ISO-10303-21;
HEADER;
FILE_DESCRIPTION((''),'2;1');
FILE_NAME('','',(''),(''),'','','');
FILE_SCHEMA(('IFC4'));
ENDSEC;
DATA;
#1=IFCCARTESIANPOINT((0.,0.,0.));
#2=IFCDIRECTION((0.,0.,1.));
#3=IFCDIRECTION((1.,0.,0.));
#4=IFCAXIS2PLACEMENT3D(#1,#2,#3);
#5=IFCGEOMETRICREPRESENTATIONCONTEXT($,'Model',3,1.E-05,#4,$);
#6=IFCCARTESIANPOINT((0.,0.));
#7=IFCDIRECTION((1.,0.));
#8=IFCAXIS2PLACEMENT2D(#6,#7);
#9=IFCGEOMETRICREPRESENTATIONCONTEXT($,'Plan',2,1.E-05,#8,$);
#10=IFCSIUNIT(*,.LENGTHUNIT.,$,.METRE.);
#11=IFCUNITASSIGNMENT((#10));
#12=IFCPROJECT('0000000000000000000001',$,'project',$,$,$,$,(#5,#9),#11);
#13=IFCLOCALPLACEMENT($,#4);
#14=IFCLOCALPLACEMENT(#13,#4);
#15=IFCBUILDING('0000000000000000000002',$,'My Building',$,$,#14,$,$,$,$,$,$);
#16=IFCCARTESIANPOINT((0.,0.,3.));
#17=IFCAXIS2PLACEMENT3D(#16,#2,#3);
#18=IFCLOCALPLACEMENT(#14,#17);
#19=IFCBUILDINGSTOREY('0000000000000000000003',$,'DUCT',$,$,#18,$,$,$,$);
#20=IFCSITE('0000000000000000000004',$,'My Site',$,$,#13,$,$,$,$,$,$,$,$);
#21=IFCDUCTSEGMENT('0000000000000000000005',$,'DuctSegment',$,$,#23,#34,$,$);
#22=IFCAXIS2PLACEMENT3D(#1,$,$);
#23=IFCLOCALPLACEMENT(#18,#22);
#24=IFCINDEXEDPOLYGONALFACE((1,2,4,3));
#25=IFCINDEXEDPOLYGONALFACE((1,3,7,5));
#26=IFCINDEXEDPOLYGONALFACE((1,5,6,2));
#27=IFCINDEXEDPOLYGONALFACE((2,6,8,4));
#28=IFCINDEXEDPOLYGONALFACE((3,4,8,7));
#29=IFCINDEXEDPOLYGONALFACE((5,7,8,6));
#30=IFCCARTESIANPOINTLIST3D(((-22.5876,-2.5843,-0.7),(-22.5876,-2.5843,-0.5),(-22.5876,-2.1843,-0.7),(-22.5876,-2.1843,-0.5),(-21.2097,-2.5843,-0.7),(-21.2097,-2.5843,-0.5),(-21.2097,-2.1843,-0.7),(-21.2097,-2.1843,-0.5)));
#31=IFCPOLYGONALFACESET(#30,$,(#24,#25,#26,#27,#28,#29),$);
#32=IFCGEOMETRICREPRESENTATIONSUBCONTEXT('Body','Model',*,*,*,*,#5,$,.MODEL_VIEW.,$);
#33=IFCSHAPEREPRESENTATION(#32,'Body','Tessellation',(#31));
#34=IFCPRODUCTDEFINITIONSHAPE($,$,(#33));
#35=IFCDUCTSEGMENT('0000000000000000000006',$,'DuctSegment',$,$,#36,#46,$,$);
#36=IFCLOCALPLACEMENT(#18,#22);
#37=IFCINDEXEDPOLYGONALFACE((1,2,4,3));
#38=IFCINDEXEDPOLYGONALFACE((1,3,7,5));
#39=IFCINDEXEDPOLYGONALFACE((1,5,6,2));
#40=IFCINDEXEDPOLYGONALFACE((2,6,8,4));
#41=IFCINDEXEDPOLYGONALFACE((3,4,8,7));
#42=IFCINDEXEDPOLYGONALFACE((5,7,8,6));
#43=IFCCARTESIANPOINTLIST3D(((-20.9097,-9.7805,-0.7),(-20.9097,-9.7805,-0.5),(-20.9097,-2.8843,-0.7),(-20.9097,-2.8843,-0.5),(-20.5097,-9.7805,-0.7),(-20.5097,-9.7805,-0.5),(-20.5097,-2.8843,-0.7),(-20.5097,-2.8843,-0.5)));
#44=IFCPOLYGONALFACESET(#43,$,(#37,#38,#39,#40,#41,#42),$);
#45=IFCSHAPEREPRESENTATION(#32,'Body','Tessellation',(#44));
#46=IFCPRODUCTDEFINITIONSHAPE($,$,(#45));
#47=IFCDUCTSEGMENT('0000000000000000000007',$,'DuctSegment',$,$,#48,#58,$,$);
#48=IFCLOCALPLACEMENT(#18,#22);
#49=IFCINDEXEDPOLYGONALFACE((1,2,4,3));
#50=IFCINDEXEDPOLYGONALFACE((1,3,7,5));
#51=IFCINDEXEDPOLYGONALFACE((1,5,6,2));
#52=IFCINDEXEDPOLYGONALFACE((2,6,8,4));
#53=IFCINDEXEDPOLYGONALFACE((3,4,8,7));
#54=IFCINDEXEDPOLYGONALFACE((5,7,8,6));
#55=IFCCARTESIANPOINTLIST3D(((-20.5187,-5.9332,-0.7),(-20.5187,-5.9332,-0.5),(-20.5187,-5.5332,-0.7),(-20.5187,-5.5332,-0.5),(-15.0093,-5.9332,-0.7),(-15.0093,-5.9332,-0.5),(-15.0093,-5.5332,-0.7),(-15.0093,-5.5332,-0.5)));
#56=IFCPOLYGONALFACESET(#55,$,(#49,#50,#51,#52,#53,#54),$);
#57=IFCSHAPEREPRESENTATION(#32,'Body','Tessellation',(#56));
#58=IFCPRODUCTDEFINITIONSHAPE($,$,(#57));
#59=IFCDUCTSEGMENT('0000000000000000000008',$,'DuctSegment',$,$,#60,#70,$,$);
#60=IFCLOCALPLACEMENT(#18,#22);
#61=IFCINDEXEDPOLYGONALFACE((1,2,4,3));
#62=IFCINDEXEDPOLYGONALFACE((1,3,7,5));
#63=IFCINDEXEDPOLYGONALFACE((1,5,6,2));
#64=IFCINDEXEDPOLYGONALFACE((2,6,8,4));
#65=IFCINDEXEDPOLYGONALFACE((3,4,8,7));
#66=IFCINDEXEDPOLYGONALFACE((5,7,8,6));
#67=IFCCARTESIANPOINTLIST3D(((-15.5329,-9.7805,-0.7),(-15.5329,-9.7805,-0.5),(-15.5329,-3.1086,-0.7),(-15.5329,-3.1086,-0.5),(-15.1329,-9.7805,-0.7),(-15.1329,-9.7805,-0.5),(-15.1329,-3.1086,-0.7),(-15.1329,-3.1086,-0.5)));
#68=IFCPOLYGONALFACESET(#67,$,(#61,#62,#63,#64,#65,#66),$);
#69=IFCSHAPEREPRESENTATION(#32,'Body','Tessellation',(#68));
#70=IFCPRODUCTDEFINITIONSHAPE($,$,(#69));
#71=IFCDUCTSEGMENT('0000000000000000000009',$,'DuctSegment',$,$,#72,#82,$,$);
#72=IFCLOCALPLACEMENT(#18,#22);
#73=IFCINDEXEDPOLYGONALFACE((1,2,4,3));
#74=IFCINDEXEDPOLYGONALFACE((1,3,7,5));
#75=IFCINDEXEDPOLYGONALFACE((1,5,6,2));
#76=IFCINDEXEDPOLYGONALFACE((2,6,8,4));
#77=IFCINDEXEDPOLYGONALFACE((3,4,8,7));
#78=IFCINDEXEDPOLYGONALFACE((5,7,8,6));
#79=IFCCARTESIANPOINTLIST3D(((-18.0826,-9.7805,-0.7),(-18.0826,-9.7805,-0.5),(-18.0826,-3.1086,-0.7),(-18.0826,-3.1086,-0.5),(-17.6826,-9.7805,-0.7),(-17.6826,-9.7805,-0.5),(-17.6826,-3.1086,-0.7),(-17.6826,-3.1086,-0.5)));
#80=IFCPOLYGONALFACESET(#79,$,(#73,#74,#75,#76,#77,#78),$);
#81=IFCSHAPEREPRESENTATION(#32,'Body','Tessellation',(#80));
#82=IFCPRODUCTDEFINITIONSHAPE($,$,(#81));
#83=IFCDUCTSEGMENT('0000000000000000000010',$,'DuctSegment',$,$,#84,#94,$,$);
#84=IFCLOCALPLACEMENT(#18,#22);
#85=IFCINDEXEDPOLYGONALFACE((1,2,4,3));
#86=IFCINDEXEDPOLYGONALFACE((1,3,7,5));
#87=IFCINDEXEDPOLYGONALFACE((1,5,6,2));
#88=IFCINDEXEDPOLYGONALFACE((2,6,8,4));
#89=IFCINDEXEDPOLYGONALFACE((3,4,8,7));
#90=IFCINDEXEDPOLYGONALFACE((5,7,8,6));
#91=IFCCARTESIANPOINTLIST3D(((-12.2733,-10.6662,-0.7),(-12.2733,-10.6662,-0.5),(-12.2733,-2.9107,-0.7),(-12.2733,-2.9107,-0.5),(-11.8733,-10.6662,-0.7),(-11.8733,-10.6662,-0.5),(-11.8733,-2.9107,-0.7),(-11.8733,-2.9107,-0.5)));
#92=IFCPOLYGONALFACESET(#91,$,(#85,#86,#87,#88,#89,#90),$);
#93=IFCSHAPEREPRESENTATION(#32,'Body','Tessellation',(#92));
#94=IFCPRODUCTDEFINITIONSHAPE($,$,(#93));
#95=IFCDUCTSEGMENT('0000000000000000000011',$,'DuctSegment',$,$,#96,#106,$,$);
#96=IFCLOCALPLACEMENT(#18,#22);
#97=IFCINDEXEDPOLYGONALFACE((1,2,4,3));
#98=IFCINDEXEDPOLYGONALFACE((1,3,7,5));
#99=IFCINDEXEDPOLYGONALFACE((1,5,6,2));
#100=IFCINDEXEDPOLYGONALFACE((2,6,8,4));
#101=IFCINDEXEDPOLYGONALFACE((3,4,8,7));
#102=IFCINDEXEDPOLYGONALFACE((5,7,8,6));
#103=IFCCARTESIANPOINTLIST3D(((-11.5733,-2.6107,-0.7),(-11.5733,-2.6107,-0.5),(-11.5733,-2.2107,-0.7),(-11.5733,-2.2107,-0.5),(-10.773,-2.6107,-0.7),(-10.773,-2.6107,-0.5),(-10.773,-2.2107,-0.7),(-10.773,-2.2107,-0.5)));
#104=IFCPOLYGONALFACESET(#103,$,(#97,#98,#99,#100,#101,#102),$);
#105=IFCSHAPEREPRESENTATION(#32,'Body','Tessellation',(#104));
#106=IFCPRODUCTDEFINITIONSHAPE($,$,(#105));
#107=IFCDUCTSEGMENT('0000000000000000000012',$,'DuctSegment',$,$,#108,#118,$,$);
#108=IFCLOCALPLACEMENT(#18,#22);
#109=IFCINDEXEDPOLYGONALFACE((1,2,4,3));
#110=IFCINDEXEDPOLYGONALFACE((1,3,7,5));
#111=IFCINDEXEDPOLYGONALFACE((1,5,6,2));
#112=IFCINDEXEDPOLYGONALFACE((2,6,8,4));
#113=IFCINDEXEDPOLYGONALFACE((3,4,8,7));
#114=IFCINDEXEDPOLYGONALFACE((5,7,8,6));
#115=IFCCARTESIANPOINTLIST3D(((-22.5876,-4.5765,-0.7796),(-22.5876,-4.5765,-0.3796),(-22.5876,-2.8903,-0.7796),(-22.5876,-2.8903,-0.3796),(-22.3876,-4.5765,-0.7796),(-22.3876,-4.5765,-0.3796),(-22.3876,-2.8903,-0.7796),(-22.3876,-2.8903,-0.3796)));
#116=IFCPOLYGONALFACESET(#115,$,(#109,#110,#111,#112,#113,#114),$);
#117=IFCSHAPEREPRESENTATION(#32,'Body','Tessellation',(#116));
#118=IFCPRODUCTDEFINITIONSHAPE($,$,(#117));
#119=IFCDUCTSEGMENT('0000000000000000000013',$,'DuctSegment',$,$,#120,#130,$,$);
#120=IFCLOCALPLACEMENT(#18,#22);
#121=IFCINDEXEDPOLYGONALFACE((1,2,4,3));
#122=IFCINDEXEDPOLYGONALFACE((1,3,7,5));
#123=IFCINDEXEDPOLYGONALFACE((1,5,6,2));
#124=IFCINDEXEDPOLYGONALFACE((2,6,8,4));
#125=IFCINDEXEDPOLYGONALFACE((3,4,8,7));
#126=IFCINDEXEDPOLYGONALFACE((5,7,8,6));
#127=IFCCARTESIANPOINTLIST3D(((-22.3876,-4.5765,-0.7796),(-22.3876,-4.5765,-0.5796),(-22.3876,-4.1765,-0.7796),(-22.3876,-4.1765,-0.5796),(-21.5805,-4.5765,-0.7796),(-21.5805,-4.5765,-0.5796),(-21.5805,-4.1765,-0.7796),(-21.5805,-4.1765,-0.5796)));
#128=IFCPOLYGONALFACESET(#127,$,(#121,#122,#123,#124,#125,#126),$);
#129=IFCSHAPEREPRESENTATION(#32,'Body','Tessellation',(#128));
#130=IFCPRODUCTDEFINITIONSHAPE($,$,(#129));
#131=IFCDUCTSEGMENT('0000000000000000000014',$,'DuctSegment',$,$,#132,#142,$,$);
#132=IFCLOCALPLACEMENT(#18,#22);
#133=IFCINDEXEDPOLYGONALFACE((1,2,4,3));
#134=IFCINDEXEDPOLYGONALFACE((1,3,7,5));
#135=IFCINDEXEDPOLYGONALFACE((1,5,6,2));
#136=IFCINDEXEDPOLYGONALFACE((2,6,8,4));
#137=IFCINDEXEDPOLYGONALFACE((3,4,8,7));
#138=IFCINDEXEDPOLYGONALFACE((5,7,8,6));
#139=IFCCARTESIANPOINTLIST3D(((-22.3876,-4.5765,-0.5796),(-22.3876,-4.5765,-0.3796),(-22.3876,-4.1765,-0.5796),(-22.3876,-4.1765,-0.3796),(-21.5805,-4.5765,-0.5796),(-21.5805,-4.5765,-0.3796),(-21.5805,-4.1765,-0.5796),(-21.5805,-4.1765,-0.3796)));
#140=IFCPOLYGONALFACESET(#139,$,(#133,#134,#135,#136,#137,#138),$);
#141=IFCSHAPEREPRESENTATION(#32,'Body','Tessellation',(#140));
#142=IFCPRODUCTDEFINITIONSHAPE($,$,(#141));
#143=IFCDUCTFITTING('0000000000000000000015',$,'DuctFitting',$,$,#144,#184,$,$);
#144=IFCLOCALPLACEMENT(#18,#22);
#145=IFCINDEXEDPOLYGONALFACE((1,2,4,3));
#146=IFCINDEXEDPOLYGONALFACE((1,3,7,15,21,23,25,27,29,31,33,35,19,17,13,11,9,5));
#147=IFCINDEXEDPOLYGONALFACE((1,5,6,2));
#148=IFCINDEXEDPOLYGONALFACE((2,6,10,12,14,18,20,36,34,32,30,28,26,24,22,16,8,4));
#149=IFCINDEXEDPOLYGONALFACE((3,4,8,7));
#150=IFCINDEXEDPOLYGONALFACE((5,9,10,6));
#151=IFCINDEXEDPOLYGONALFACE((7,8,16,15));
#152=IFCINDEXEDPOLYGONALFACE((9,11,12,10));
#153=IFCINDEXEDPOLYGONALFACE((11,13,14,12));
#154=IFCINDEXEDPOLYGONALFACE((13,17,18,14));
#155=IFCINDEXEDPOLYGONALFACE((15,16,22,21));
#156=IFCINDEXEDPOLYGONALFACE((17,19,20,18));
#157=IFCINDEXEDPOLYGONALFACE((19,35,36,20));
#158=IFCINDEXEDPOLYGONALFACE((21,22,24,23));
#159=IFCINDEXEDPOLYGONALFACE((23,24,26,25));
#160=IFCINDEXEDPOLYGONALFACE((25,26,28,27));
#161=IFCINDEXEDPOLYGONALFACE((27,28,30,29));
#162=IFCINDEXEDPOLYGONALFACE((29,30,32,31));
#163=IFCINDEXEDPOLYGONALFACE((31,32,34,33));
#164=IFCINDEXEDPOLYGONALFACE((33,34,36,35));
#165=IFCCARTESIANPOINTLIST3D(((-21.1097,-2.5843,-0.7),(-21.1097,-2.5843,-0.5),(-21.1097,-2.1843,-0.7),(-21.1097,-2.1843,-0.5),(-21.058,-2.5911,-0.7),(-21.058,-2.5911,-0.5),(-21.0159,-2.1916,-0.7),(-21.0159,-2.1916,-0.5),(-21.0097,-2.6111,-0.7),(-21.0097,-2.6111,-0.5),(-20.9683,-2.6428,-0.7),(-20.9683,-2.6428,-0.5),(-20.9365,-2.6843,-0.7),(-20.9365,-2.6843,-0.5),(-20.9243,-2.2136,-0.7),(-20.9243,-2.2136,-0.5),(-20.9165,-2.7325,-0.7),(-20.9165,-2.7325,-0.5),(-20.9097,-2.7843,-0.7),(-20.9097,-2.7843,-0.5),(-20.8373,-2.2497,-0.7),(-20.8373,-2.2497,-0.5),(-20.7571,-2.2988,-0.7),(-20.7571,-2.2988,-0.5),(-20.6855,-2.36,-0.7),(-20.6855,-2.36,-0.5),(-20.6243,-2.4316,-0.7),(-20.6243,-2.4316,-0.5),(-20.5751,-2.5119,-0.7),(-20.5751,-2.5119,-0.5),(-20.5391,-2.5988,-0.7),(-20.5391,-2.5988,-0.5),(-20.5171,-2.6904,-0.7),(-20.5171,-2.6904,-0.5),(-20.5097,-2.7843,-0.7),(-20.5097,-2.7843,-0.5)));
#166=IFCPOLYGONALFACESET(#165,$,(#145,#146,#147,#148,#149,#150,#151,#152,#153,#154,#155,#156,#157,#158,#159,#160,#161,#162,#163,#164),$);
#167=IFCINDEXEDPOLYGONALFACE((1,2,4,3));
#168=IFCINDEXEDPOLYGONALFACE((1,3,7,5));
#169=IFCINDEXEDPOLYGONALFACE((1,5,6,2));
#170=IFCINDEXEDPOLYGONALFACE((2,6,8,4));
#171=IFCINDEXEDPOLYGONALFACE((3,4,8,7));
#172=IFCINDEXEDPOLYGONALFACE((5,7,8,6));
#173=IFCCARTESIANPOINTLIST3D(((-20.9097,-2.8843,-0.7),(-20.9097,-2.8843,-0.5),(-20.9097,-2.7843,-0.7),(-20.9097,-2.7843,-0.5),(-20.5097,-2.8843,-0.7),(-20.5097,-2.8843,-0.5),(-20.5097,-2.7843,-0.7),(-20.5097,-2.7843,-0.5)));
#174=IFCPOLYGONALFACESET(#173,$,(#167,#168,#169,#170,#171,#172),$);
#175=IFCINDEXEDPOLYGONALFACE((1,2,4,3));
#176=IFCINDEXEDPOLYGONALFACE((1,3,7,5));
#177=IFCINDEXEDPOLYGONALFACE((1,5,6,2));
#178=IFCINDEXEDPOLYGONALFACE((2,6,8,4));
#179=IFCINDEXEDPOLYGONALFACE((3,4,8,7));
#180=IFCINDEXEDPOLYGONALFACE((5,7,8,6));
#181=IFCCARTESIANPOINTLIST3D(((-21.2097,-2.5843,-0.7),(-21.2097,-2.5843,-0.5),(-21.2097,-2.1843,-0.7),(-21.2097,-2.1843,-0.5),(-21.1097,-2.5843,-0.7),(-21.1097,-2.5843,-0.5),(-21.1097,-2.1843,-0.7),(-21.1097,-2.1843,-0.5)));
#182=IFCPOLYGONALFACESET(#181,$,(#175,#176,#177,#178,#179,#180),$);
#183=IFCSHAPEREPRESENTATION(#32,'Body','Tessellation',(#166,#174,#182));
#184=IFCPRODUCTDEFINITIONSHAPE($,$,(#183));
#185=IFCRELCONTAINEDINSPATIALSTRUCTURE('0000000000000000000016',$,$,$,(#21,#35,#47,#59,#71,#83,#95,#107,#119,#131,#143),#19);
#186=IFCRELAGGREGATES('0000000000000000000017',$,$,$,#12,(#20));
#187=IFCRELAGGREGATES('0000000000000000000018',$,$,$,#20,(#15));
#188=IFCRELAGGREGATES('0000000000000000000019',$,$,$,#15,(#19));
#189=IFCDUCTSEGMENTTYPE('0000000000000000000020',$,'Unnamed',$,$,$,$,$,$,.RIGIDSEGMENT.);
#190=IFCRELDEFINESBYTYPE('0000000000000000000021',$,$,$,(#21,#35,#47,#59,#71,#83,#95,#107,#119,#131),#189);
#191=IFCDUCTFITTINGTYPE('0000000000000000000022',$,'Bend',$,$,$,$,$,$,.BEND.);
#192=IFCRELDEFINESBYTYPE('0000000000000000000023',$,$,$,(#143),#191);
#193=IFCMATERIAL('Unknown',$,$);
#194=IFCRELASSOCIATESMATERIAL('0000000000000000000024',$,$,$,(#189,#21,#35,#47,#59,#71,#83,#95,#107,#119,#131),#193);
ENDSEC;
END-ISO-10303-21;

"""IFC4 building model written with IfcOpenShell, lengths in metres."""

from ifc_helpers import new_model, si_unit, frame, origin_with_axes, origin_2d_with_axis, place, context, subcontext, project, spatial, line, arc, indexed_curve, rectangle, outline, extrude, source, transform, mapped, material, material_profile, profile_set, profile_usage, type_object, type_shapes, element, save


model = new_model("IFC4")

# Units and contexts
model_context = context("Model", 3, precision=1e-05, world=origin_with_axes())
plan_context = context("Plan", 2, precision=1e-05, world=origin_2d_with_axis())
body_context = subcontext(model_context, "Body", "Model", "MODEL_VIEW")
ifc_project = project(units=[si_unit("LENGTHUNIT", "METRE")], contexts=[model_context, plan_context])

# Site, building, storey
site_placement = place(None, origin_with_axes())
site = spatial("IfcSite", under=ifc_project, at=site_placement, Name="My Site")
building_placement = place(site_placement, origin_with_axes())
building = spatial("IfcBuilding", under=site, at=building_placement, Name="My Building")
storey_placement = place(building_placement, frame((0.0, 0.0, 3.0), z_axis=(0.0, 0.0, 1.0), x_axis=(1.0, 0.0, 0.0)))
storey = spatial("IfcBuildingStorey", under=building, at=storey_placement, Name="DUCT")

# Duct segments
ifc_material = material(Name="Unknown")
ifc_material_profile = material_profile(ifc_material, rectangle(XDim=0.4, YDim=0.2))
ifc_profile_set = profile_set([ifc_material_profile])
ifc_profile_usage_1 = profile_usage(ifc_profile_set, cardinal=5)
duct_segment_type = type_object("IfcDuctSegmentType", Name="Unnamed", PredefinedType="RIGIDSEGMENT", material=ifc_profile_set)
duct_segment_1_placement = place(storey_placement, frame((-22.5876, -2.3843, -0.6), z_axis=(1.0, 0.0, 0.0), x_axis=(0.0, 1.0, 0.0)))
element("IfcDuctSegment", 1, at=duct_segment_1_placement, inside=storey, type_object=duct_segment_type, material=ifc_profile_usage_1, Name="DuctSegment", context=body_context, shape_type="SweptSolid", body=[
    extrude(rectangle(XDim=0.4, YDim=0.2), origin_with_axes(), (0.0, 0.0, 1.0), 1.3778),
])
ifc_profile_usage_2 = profile_usage(ifc_profile_set, cardinal=5)
duct_segment_2_placement = place(storey_placement, frame((-20.7097, -2.8843, -0.6), z_axis=(0.0, -1.0, 0.0), x_axis=(1.0, 0.0, 0.0)))
element("IfcDuctSegment", 2, at=duct_segment_2_placement, inside=storey, type_object=duct_segment_type, material=ifc_profile_usage_2, Name="DuctSegment", context=body_context, shape_type="SweptSolid", body=[
    extrude(rectangle(XDim=0.4, YDim=0.2), origin_with_axes(), (0.0, 0.0, 1.0), 6.8962),
])
ifc_profile_usage_3 = profile_usage(ifc_profile_set, cardinal=5)
duct_segment_3_placement = place(storey_placement, frame((-20.5187, -5.7332, -0.6), z_axis=(1.0, 0.0, 0.0), x_axis=(0.0, 1.0, 0.0)))
element("IfcDuctSegment", 3, at=duct_segment_3_placement, inside=storey, type_object=duct_segment_type, material=ifc_profile_usage_3, Name="DuctSegment", context=body_context, shape_type="SweptSolid", body=[
    extrude(rectangle(XDim=0.4, YDim=0.2), origin_with_axes(), (0.0, 0.0, 1.0), 5.5094),
])
ifc_profile_usage_4 = profile_usage(ifc_profile_set, cardinal=5)
duct_segment_4_placement = place(storey_placement, frame((-15.3329, -3.1086, -0.6), z_axis=(0.0, -1.0, 0.0), x_axis=(1.0, 0.0, 0.0)))
element("IfcDuctSegment", 4, at=duct_segment_4_placement, inside=storey, type_object=duct_segment_type, material=ifc_profile_usage_4, Name="DuctSegment", context=body_context, shape_type="SweptSolid", body=[
    extrude(rectangle(XDim=0.4, YDim=0.2), origin_with_axes(), (0.0, 0.0, 1.0), 6.6718),
])
ifc_profile_usage_5 = profile_usage(ifc_profile_set, cardinal=5)
duct_segment_5_placement = place(storey_placement, frame((-17.8826, -3.1086, -0.6), z_axis=(0.0, -1.0, 0.0), x_axis=(1.0, 0.0, 0.0)))
element("IfcDuctSegment", 5, at=duct_segment_5_placement, inside=storey, type_object=duct_segment_type, material=ifc_profile_usage_5, Name="DuctSegment", context=body_context, shape_type="SweptSolid", body=[
    extrude(rectangle(XDim=0.4, YDim=0.2), origin_with_axes(), (0.0, 0.0, 1.0), 6.6718),
])
ifc_profile_usage_6 = profile_usage(ifc_profile_set, cardinal=5)
duct_segment_6_placement = place(storey_placement, frame((-12.0733, -2.9107, -0.6), z_axis=(0.0, -1.0, 0.0), x_axis=(1.0, 0.0, 0.0)))
element("IfcDuctSegment", 6, at=duct_segment_6_placement, inside=storey, type_object=duct_segment_type, material=ifc_profile_usage_6, Name="DuctSegment", context=body_context, shape_type="SweptSolid", body=[
    extrude(rectangle(XDim=0.4, YDim=0.2), origin_with_axes(), (0.0, 0.0, 1.0), 7.7556),
])
ifc_profile_usage_7 = profile_usage(ifc_profile_set, cardinal=5)
duct_segment_7_placement = place(storey_placement, frame((-11.5733, -2.4107, -0.6), z_axis=(1.0, 0.0, 0.0), x_axis=(0.0, 1.0, 0.0)))
element("IfcDuctSegment", 7, at=duct_segment_7_placement, inside=storey, type_object=duct_segment_type, material=ifc_profile_usage_7, Name="DuctSegment", context=body_context, shape_type="SweptSolid", body=[
    extrude(rectangle(XDim=0.4, YDim=0.2), origin_with_axes(), (0.0, 0.0, 1.0), 0.8003),
])
ifc_profile_usage_8 = profile_usage(ifc_profile_set, cardinal=5)
duct_segment_8_placement = place(storey_placement, frame((-22.4876, -2.8903, -0.5796), z_axis=(0.0, -1.0, 0.0), x_axis=(0.0, 0.0, -1.0)))
element("IfcDuctSegment", 8, at=duct_segment_8_placement, inside=storey, type_object=duct_segment_type, material=ifc_profile_usage_8, Name="DuctSegment", context=body_context, shape_type="SweptSolid", body=[
    extrude(rectangle(XDim=0.4, YDim=0.2), origin_with_axes(), (0.0, 0.0, 1.0), 1.6863),
])
ifc_profile_usage_9 = profile_usage(ifc_profile_set, cardinal=5)
duct_segment_9_placement = place(storey_placement, frame((-22.3876, -4.3765, -0.6796), z_axis=(1.0, 0.0, 0.0), x_axis=(0.0, 1.0, 0.0)))
element("IfcDuctSegment", 9, at=duct_segment_9_placement, inside=storey, type_object=duct_segment_type, material=ifc_profile_usage_9, Name="DuctSegment", context=body_context, shape_type="SweptSolid", body=[
    extrude(rectangle(XDim=0.4, YDim=0.2), origin_with_axes(), (0.0, 0.0, 1.0), 0.8071),
])
ifc_profile_usage_10 = profile_usage(ifc_profile_set, cardinal=5)
duct_segment_10_placement = place(storey_placement, frame((-22.3876, -4.3765, -0.4796), z_axis=(1.0, 0.0, 0.0), x_axis=(0.0, 1.0, 0.0)))
element("IfcDuctSegment", 10, at=duct_segment_10_placement, inside=storey, type_object=duct_segment_type, material=ifc_profile_usage_10, Name="DuctSegment", context=body_context, shape_type="SweptSolid", body=[
    extrude(rectangle(XDim=0.4, YDim=0.2), origin_with_axes(), (0.0, 0.0, 1.0), 0.8071),
])

# Duct fitting
duct_fitting_type = type_object("IfcDuctFittingType", Name="Bend", PredefinedType="BEND")
shared_shape = source(origin_with_axes(), body_context, "Body", "SweptSolid", [
    extrude(outline(indexed_curve([(-0.2, 0.0), (-0.2586, -0.1414), (-0.4, -0.2), (-0.4, -0.6), (0.0243, -0.4243), (0.2, 0.0)], segments=[arc(1, 2, 3), line(3, 4), arc(4, 5, 6), line(6, 1)])), frame((0.0, -0.1, -0.1), z_axis=(0.0, -1.0, 0.0), x_axis=(1.0, 0.0, 0.0)), (0.0, 0.0, -1.0), 0.2),
    extrude(rectangle(XDim=0.4, YDim=0.2), origin_with_axes(), (0.0, 0.0, -1.0), 0.1),
    extrude(rectangle(XDim=0.4, YDim=0.2), frame((-0.4, 0.0, -0.5), z_axis=(-1.0, 0.0, 0.0), x_axis=(0.0, 0.0, -1.0)), (0.0, 0.0, 1.0), 0.1),
])
type_shapes(duct_fitting_type, [shared_shape])
for number, where, z_axis, x_axis, name in (
    (11, (-20.7097, -2.8843, -0.6), (0.0, -1.0, 0.0), (1.0, 0.0, 0.0), "DuctFitting"),
):
    element("IfcDuctFitting", number, at=place(storey_placement, frame(where, z_axis=z_axis, x_axis=x_axis)), inside=storey, type_object=duct_fitting_type, Name=name, context=body_context, shape_type="MappedRepresentation", body=[
        mapped(shared_shape, transform((0.0, 0.0, 0.0), x_axis=(1.0, 0.0, 0.0), y_axis=(0.0, 1.0, 0.0), z_axis=(0.0, 0.0, 1.0), scale=1.0)),
    ])

save(model, "model.ifc")
